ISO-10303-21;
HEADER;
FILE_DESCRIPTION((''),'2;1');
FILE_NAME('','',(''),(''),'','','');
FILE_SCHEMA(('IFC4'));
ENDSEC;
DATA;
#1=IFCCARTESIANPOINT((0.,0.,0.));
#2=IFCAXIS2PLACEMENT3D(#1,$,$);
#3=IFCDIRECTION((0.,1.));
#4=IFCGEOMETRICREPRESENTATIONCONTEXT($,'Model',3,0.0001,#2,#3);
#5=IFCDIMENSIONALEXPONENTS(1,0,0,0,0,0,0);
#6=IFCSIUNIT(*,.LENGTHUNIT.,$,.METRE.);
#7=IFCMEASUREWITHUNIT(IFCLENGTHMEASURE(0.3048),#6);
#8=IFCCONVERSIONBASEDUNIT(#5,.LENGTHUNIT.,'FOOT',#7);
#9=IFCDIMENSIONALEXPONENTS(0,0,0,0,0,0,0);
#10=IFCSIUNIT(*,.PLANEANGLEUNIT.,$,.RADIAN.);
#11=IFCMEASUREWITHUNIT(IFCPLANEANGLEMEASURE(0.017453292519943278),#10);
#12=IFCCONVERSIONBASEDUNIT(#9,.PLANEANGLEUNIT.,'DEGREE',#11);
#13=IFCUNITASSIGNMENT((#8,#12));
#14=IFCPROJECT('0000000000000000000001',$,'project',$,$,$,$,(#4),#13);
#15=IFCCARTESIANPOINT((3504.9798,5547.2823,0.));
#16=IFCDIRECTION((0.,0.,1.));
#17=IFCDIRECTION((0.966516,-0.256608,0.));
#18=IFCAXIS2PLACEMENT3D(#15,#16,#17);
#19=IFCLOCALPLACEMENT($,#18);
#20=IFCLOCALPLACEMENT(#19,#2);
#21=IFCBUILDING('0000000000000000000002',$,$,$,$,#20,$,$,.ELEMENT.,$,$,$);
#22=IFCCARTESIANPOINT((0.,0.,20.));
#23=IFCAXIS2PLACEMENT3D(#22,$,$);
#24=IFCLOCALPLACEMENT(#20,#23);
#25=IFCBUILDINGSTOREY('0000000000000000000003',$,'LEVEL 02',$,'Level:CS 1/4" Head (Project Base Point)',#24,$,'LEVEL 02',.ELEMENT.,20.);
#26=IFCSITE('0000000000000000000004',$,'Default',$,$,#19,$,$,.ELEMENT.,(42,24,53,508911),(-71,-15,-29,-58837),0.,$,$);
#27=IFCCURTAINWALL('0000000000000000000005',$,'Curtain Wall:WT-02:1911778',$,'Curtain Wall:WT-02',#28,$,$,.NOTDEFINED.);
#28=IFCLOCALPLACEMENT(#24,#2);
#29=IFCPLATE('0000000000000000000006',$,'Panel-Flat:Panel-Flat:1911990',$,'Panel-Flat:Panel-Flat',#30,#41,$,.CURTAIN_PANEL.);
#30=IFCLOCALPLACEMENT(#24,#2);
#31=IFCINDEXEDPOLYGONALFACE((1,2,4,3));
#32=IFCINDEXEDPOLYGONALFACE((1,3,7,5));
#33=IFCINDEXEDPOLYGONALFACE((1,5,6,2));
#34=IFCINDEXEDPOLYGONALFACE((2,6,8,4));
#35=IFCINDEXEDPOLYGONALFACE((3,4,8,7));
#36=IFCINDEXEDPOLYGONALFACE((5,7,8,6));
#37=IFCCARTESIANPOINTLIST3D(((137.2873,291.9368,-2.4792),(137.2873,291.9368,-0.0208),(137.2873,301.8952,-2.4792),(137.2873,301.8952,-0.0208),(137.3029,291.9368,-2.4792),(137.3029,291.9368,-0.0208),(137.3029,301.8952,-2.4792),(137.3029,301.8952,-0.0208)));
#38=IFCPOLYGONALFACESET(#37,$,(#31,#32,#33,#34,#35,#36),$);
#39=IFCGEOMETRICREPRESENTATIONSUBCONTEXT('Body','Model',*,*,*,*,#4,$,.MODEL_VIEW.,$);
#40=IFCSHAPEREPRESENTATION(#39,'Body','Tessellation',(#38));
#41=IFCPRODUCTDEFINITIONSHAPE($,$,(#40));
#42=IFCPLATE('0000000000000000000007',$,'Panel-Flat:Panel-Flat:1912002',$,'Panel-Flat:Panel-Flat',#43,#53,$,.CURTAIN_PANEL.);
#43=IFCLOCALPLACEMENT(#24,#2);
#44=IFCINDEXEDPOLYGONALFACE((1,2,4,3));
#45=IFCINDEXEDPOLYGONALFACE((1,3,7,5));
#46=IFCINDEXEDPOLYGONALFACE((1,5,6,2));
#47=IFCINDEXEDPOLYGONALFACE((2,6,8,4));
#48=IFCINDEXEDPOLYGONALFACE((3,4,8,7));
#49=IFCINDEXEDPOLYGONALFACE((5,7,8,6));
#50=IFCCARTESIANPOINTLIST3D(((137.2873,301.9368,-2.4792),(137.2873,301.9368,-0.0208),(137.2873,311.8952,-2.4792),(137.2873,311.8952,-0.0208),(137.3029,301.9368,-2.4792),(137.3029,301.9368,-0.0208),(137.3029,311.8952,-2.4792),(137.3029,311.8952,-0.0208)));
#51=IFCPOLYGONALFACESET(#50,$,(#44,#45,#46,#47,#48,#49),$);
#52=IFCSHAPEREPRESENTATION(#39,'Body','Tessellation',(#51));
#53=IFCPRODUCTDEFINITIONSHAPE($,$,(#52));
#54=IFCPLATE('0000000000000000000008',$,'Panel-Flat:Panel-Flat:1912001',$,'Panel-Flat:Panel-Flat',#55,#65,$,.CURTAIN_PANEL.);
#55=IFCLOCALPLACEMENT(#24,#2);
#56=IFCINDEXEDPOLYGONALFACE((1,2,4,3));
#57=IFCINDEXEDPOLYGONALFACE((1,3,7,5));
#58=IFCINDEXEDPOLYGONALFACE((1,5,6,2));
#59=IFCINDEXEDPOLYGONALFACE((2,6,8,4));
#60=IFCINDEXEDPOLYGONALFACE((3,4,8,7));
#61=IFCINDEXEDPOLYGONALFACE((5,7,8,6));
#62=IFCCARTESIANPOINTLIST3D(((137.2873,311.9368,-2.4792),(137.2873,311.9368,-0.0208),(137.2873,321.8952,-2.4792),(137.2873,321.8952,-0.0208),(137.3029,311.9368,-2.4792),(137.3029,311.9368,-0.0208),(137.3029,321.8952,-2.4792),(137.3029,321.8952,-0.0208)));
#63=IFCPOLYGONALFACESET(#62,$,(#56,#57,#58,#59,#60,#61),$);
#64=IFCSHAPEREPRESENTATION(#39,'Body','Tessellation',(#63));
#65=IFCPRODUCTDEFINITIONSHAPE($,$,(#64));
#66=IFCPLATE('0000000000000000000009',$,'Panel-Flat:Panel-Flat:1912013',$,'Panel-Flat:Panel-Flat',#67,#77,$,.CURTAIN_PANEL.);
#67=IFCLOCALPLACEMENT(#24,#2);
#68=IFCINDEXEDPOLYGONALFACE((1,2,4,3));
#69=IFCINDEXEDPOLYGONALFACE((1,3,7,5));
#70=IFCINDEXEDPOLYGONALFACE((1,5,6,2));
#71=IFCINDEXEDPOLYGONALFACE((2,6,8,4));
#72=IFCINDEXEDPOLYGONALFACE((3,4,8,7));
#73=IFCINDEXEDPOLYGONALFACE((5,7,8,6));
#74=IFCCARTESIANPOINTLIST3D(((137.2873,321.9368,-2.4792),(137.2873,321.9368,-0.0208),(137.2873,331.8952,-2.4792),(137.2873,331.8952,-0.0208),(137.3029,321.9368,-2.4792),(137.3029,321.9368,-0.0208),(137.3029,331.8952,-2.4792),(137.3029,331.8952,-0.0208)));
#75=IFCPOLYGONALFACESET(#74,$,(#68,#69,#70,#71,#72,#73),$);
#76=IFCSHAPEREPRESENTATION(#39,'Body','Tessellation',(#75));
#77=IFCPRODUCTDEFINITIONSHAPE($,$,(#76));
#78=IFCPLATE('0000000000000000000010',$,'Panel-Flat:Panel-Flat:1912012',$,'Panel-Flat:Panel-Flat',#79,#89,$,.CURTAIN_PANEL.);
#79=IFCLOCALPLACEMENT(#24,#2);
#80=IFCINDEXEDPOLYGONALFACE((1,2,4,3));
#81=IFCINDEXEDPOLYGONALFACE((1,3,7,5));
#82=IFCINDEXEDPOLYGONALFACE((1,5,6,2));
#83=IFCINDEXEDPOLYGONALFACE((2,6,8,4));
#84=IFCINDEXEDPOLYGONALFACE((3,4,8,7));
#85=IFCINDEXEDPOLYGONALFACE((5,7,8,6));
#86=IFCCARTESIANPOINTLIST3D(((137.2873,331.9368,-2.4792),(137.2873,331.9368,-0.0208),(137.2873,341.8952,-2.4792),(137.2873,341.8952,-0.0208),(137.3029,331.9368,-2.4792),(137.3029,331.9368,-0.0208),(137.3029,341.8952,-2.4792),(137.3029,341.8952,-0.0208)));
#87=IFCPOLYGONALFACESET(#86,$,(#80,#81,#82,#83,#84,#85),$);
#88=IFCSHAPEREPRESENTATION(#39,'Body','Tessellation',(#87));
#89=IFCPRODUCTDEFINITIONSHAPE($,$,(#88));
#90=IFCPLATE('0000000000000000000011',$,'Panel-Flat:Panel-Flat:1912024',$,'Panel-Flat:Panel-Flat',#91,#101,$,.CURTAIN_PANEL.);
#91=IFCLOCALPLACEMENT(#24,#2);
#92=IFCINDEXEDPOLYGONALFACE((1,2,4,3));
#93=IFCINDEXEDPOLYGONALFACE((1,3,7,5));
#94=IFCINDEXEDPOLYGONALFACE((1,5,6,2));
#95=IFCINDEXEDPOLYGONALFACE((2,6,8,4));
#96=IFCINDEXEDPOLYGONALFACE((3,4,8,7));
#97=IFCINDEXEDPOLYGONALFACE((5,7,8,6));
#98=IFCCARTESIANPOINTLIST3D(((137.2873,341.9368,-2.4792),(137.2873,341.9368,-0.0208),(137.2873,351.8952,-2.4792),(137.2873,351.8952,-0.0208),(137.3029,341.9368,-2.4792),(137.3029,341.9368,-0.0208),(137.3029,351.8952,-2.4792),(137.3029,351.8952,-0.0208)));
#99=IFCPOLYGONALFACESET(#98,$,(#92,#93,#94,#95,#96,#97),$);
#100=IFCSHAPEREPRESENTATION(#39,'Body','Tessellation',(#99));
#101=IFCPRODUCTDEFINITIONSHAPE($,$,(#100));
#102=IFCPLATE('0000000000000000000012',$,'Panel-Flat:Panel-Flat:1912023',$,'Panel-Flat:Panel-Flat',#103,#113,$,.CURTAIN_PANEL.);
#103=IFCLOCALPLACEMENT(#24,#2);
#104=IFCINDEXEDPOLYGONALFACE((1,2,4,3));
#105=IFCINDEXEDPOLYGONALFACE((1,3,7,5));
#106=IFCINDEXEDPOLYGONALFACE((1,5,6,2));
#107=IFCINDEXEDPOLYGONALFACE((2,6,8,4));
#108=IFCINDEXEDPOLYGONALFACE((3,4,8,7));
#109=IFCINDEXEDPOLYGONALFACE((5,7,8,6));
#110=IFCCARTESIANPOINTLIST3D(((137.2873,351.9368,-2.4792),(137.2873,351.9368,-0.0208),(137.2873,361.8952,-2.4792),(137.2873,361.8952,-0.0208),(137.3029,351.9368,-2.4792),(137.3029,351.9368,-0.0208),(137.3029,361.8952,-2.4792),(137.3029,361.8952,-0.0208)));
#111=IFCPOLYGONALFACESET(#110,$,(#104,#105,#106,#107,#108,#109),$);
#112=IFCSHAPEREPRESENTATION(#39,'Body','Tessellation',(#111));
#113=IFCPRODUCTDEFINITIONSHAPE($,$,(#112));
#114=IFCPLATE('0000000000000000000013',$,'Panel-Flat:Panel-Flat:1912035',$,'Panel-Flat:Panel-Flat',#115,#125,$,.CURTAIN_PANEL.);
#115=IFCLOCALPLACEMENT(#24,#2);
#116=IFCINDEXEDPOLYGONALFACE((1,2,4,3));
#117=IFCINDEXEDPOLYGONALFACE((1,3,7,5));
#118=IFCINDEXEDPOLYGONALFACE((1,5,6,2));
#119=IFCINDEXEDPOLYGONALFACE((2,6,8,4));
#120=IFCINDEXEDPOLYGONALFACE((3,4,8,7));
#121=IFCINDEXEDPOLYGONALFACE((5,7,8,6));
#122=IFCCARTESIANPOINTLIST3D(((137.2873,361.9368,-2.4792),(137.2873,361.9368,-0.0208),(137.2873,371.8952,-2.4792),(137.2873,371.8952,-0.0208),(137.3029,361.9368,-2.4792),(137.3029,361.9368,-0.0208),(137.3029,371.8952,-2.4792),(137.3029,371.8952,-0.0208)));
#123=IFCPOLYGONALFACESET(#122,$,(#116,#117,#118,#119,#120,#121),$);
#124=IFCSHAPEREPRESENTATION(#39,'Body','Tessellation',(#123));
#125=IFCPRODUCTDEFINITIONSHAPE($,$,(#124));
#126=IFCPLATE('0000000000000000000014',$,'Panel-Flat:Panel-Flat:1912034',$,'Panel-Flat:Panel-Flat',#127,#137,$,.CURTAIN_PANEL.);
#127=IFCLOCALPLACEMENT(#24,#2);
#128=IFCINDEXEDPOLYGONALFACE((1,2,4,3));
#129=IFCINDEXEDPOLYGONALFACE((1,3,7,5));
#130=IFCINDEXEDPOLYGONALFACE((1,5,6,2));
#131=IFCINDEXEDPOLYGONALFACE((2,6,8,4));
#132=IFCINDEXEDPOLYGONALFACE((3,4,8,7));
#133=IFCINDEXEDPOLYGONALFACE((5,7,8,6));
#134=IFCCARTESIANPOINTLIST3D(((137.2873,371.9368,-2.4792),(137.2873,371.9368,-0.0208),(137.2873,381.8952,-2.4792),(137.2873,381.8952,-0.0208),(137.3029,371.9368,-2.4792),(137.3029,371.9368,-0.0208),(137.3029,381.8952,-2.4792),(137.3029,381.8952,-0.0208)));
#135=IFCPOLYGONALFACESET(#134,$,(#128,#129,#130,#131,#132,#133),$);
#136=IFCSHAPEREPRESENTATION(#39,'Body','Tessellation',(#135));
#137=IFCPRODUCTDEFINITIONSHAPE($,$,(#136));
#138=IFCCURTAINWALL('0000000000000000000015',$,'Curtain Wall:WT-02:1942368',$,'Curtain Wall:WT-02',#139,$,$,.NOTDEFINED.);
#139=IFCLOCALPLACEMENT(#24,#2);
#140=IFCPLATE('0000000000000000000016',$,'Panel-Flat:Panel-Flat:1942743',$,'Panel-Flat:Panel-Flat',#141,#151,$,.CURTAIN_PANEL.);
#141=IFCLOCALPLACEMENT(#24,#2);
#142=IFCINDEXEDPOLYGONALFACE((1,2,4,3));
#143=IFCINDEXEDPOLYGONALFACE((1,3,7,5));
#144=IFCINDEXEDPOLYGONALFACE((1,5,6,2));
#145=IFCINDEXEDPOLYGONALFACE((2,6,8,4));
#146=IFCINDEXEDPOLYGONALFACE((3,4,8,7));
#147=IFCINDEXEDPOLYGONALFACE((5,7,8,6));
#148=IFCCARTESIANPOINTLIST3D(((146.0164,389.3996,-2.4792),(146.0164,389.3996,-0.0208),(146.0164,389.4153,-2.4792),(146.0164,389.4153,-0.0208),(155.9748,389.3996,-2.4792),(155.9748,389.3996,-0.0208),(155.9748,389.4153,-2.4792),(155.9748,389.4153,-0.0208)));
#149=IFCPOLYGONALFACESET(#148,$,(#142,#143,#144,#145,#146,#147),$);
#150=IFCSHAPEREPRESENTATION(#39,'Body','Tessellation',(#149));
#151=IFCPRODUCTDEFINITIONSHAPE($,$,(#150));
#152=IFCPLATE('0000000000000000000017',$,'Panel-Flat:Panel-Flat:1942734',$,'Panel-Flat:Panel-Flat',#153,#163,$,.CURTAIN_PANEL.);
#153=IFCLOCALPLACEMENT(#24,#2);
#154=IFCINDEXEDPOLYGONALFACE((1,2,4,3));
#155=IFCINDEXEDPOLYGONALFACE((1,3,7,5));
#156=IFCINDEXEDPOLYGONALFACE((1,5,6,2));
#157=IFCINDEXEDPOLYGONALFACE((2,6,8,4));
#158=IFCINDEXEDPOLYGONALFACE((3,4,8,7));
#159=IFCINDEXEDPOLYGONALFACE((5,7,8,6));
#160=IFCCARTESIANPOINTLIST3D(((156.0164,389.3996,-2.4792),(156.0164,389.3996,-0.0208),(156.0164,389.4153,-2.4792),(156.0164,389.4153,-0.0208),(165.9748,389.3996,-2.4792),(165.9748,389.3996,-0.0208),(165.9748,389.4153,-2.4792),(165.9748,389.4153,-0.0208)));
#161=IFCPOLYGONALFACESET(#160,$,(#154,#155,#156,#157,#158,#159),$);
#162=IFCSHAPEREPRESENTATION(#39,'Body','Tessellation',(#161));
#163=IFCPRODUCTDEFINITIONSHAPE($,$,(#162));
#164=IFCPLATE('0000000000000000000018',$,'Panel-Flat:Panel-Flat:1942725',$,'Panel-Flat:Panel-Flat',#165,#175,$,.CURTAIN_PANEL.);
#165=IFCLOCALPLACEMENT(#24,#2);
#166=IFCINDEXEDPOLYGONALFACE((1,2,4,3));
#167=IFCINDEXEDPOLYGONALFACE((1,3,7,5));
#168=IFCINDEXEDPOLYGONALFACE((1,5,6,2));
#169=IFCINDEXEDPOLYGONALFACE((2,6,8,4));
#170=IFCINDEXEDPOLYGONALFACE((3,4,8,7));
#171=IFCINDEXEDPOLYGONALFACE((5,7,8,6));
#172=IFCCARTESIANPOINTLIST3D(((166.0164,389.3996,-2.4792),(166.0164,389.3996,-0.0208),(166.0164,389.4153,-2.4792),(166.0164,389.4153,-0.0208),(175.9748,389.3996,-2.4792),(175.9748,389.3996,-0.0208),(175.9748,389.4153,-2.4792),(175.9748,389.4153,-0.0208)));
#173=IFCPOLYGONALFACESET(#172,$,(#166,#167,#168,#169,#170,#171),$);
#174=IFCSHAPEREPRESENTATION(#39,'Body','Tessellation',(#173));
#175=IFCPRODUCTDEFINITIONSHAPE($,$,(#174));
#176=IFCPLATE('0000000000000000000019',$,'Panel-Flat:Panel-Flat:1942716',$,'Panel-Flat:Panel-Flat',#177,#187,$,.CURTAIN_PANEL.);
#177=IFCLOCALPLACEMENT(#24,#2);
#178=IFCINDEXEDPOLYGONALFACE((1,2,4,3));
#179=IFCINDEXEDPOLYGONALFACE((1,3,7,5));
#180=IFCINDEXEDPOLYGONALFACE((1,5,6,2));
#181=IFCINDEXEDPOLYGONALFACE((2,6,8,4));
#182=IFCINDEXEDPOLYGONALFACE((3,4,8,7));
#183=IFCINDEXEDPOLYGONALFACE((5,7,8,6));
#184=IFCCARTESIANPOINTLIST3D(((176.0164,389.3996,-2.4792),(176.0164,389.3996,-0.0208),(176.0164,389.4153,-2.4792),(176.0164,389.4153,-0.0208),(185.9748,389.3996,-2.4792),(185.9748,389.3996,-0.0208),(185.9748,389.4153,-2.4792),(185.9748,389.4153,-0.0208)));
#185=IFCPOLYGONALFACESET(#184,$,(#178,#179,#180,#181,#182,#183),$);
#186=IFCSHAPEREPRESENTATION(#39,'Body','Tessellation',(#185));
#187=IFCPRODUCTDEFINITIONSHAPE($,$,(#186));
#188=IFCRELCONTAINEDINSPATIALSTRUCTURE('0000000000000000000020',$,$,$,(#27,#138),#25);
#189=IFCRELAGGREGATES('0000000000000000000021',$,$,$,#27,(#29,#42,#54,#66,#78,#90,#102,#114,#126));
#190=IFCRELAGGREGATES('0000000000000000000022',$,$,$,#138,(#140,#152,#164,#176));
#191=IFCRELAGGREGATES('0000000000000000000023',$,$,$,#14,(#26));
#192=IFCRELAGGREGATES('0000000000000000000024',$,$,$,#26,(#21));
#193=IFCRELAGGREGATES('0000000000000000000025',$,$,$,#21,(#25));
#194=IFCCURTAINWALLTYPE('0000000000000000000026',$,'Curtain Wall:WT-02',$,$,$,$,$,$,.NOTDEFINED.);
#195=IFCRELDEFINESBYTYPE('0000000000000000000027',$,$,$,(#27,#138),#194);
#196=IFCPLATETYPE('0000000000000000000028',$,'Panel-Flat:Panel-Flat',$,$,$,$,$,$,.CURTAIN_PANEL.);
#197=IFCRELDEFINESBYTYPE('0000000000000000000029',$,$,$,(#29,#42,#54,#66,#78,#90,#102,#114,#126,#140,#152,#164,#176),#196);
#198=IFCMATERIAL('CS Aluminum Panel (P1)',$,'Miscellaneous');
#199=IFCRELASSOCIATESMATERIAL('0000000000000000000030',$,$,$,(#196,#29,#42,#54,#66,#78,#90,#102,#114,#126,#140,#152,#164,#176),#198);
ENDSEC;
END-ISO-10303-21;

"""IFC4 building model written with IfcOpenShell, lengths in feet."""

from ifc_helpers import new_model, entity, si_unit, converted_unit, direction, frame, origin, place, context, subcontext, project, spatial, indexed_curve, outline, extrude, source, transform, mapped, material, type_object, type_shapes, element, aggregate, save


model = new_model("IFC4")

# Units and contexts
model_context = context("Model", 3, precision=0.0001, world=origin(), true_north=direction((0.0, 1.0)))
body_context = subcontext(model_context, "Body", "Model", "MODEL_VIEW")
ifc_project = project(units=[converted_unit("LENGTHUNIT", "FOOT", entity("IfcLengthMeasure", 0.3048), si_unit("LENGTHUNIT", "METRE"), dimensions=[1, 0, 0, 0, 0, 0, 0]), converted_unit("PLANEANGLEUNIT", "DEGREE", entity("IfcPlaneAngleMeasure", 0.017453292519943278), si_unit("PLANEANGLEUNIT", "RADIAN"), dimensions=[0, 0, 0, 0, 0, 0, 0])], contexts=[model_context])

# Site, building, storey
site_placement = place(None, frame((3504.9798, 5547.2823, 0.0), z_axis=(0.0, 0.0, 1.0), x_axis=(0.966516, -0.256608, 0.0)))
site = spatial("IfcSite", under=ifc_project, at=site_placement, Name="Default", CompositionType="ELEMENT", RefLatitude=(42, 24, 53, 508911), RefLongitude=(-71, -15, -29, -58837), RefElevation=0.0)
building_placement = place(site_placement, origin())
building = spatial("IfcBuilding", under=site, at=building_placement, CompositionType="ELEMENT")
storey_placement = place(building_placement, frame((0.0, 0.0, 20.0)))
storey = spatial("IfcBuildingStorey", under=building, at=storey_placement, Name="LEVEL 02", ObjectType="Level:CS 1/4\" Head (Project Base Point)", LongName="LEVEL 02", CompositionType="ELEMENT", Elevation=20.0)

# Curtain walls, plates
curtain_wall_type_1 = type_object("IfcCurtainWallType", Name="Curtain Wall:WT-02", PredefinedType="NOTDEFINED")
curtain_wall_1_placement = place(storey_placement, frame((0.0, 0.0, -20.0)))
curtain_wall_1 = element("IfcCurtainWall", 1, at=curtain_wall_1_placement, inside=storey, type_object=curtain_wall_type_1, Name="Curtain Wall:WT-02:1911778", ObjectType="Curtain Wall:WT-02", PredefinedType="NOTDEFINED")
ifc_material_1 = material(Name="CS Aluminum Panel (P1)", Category="Miscellaneous")
plate_type_1 = type_object("IfcPlateType", Name="Panel-Flat:Panel-Flat", PredefinedType="CURTAIN_PANEL", material=ifc_material_1)
shared_shape_1 = source(origin(), body_context, "Body", "SweptSolid", [
    extrude(outline(indexed_curve([(-0.0078, -4.9792), (0.0078, -4.9792), (0.0078, 4.9792), (-0.0078, 4.9792), (-0.0078, -4.9792)], self_intersect=False)), frame((4.9792, 0.0078, 0.0), z_axis=(0.0, 0.0, 1.0), x_axis=(0.0, -1.0, 0.0)), (0.0, 0.0, 1.0), 2.4583),
])
type_shapes(plate_type_1, [shared_shape_1])
plate_1_placement = place(curtain_wall_1_placement, frame((137.3029, 291.9368, 17.5208), z_axis=(0.0, 0.0, 1.0), x_axis=(0.0, 1.0, 0.0)))
plate_1 = element("IfcPlate", 2, at=plate_1_placement, type_object=plate_type_1, material=ifc_material_1, Name="Panel-Flat:Panel-Flat:1911990", ObjectType="Panel-Flat:Panel-Flat", PredefinedType="CURTAIN_PANEL", context=body_context, shape_type="MappedRepresentation", body=[
    mapped(shared_shape_1, transform((0.0, 0.0, 0.0), scale=1.0)),
])
plate_2_placement = place(curtain_wall_1_placement, frame((137.3029, 301.9368, 17.5208), z_axis=(0.0, 0.0, 1.0), x_axis=(0.0, 1.0, 0.0)))
plate_2 = element("IfcPlate", 3, at=plate_2_placement, type_object=plate_type_1, material=ifc_material_1, Name="Panel-Flat:Panel-Flat:1912002", ObjectType="Panel-Flat:Panel-Flat", PredefinedType="CURTAIN_PANEL", context=body_context, shape_type="MappedRepresentation", body=[
    mapped(shared_shape_1, transform((0.0, 0.0, 0.0), scale=1.0)),
])
plate_3_placement = place(curtain_wall_1_placement, frame((137.3029, 311.9368, 17.5208), z_axis=(0.0, 0.0, 1.0), x_axis=(0.0, 1.0, 0.0)))
plate_3 = element("IfcPlate", 4, at=plate_3_placement, type_object=plate_type_1, material=ifc_material_1, Name="Panel-Flat:Panel-Flat:1912001", ObjectType="Panel-Flat:Panel-Flat", PredefinedType="CURTAIN_PANEL", context=body_context, shape_type="MappedRepresentation", body=[
    mapped(shared_shape_1, transform((0.0, 0.0, 0.0), scale=1.0)),
])
plate_4_placement = place(curtain_wall_1_placement, frame((137.3029, 321.9368, 17.5208), z_axis=(0.0, 0.0, 1.0), x_axis=(0.0, 1.0, 0.0)))
plate_4 = element("IfcPlate", 5, at=plate_4_placement, type_object=plate_type_1, material=ifc_material_1, Name="Panel-Flat:Panel-Flat:1912013", ObjectType="Panel-Flat:Panel-Flat", PredefinedType="CURTAIN_PANEL", context=body_context, shape_type="MappedRepresentation", body=[
    mapped(shared_shape_1, transform((0.0, 0.0, 0.0), scale=1.0)),
])
plate_5_placement = place(curtain_wall_1_placement, frame((137.3029, 331.9368, 17.5208), z_axis=(0.0, 0.0, 1.0), x_axis=(0.0, 1.0, 0.0)))
plate_5 = element("IfcPlate", 6, at=plate_5_placement, type_object=plate_type_1, material=ifc_material_1, Name="Panel-Flat:Panel-Flat:1912012", ObjectType="Panel-Flat:Panel-Flat", PredefinedType="CURTAIN_PANEL", context=body_context, shape_type="MappedRepresentation", body=[
    mapped(shared_shape_1, transform((0.0, 0.0, 0.0), scale=1.0)),
])
plate_6_placement = place(curtain_wall_1_placement, frame((137.3029, 341.9368, 17.5208), z_axis=(0.0, 0.0, 1.0), x_axis=(0.0, 1.0, 0.0)))
plate_6 = element("IfcPlate", 7, at=plate_6_placement, type_object=plate_type_1, material=ifc_material_1, Name="Panel-Flat:Panel-Flat:1912024", ObjectType="Panel-Flat:Panel-Flat", PredefinedType="CURTAIN_PANEL", context=body_context, shape_type="MappedRepresentation", body=[
    mapped(shared_shape_1, transform((0.0, 0.0, 0.0), scale=1.0)),
])
plate_7_placement = place(curtain_wall_1_placement, frame((137.3029, 351.9368, 17.5208), z_axis=(0.0, 0.0, 1.0), x_axis=(0.0, 1.0, 0.0)))
plate_7 = element("IfcPlate", 8, at=plate_7_placement, type_object=plate_type_1, material=ifc_material_1, Name="Panel-Flat:Panel-Flat:1912023", ObjectType="Panel-Flat:Panel-Flat", PredefinedType="CURTAIN_PANEL", context=body_context, shape_type="MappedRepresentation", body=[
    mapped(shared_shape_1, transform((0.0, 0.0, 0.0), scale=1.0)),
])
plate_8_placement = place(curtain_wall_1_placement, frame((137.3029, 361.9368, 17.5208), z_axis=(0.0, 0.0, 1.0), x_axis=(0.0, 1.0, 0.0)))
plate_8 = element("IfcPlate", 9, at=plate_8_placement, type_object=plate_type_1, material=ifc_material_1, Name="Panel-Flat:Panel-Flat:1912035", ObjectType="Panel-Flat:Panel-Flat", PredefinedType="CURTAIN_PANEL", context=body_context, shape_type="MappedRepresentation", body=[
    mapped(shared_shape_1, transform((0.0, 0.0, 0.0), scale=1.0)),
])
plate_9_placement = place(curtain_wall_1_placement, frame((137.3029, 371.9368, 17.5208), z_axis=(0.0, 0.0, 1.0), x_axis=(0.0, 1.0, 0.0)))
plate_9 = element("IfcPlate", 10, at=plate_9_placement, type_object=plate_type_1, material=ifc_material_1, Name="Panel-Flat:Panel-Flat:1912034", ObjectType="Panel-Flat:Panel-Flat", PredefinedType="CURTAIN_PANEL", context=body_context, shape_type="MappedRepresentation", body=[
    mapped(shared_shape_1, transform((0.0, 0.0, 0.0), scale=1.0)),
])
curtain_wall_2_placement = place(storey_placement, frame((0.0, 0.0, -20.0)))
curtain_wall_2 = element("IfcCurtainWall", 11, at=curtain_wall_2_placement, inside=storey, type_object=curtain_wall_type_1, Name="Curtain Wall:WT-02:1942368", ObjectType="Curtain Wall:WT-02", PredefinedType="NOTDEFINED")
plate_10_placement = place(curtain_wall_2_placement, frame((146.0164, 389.3996, 17.5208)))
plate_10 = element("IfcPlate", 12, at=plate_10_placement, type_object=plate_type_1, material=ifc_material_1, Name="Panel-Flat:Panel-Flat:1942743", ObjectType="Panel-Flat:Panel-Flat", PredefinedType="CURTAIN_PANEL", context=body_context, shape_type="MappedRepresentation", body=[
    mapped(shared_shape_1, transform((0.0, 0.0, 0.0), scale=1.0)),
])
plate_11_placement = place(curtain_wall_2_placement, frame((156.0164, 389.3996, 17.5208)))
plate_11 = element("IfcPlate", 13, at=plate_11_placement, type_object=plate_type_1, material=ifc_material_1, Name="Panel-Flat:Panel-Flat:1942734", ObjectType="Panel-Flat:Panel-Flat", PredefinedType="CURTAIN_PANEL", context=body_context, shape_type="MappedRepresentation", body=[
    mapped(shared_shape_1, transform((0.0, 0.0, 0.0), scale=1.0)),
])
plate_12_placement = place(curtain_wall_2_placement, frame((166.0164, 389.3996, 17.5208)))
plate_12 = element("IfcPlate", 14, at=plate_12_placement, type_object=plate_type_1, material=ifc_material_1, Name="Panel-Flat:Panel-Flat:1942725", ObjectType="Panel-Flat:Panel-Flat", PredefinedType="CURTAIN_PANEL", context=body_context, shape_type="MappedRepresentation", body=[
    mapped(shared_shape_1, transform((0.0, 0.0, 0.0), scale=1.0)),
])
plate_13_placement = place(curtain_wall_2_placement, frame((176.0164, 389.3996, 17.5208)))
plate_13 = element("IfcPlate", 15, at=plate_13_placement, type_object=plate_type_1, material=ifc_material_1, Name="Panel-Flat:Panel-Flat:1942716", ObjectType="Panel-Flat:Panel-Flat", PredefinedType="CURTAIN_PANEL", context=body_context, shape_type="MappedRepresentation", body=[
    mapped(shared_shape_1, transform((0.0, 0.0, 0.0), scale=1.0)),
])

aggregate(curtain_wall_1, [plate_1, plate_2, plate_3, plate_4, plate_5, plate_6, plate_7, plate_8, plate_9])
aggregate(curtain_wall_2, [plate_10, plate_11, plate_12, plate_13])

save(model, "model.ifc")
